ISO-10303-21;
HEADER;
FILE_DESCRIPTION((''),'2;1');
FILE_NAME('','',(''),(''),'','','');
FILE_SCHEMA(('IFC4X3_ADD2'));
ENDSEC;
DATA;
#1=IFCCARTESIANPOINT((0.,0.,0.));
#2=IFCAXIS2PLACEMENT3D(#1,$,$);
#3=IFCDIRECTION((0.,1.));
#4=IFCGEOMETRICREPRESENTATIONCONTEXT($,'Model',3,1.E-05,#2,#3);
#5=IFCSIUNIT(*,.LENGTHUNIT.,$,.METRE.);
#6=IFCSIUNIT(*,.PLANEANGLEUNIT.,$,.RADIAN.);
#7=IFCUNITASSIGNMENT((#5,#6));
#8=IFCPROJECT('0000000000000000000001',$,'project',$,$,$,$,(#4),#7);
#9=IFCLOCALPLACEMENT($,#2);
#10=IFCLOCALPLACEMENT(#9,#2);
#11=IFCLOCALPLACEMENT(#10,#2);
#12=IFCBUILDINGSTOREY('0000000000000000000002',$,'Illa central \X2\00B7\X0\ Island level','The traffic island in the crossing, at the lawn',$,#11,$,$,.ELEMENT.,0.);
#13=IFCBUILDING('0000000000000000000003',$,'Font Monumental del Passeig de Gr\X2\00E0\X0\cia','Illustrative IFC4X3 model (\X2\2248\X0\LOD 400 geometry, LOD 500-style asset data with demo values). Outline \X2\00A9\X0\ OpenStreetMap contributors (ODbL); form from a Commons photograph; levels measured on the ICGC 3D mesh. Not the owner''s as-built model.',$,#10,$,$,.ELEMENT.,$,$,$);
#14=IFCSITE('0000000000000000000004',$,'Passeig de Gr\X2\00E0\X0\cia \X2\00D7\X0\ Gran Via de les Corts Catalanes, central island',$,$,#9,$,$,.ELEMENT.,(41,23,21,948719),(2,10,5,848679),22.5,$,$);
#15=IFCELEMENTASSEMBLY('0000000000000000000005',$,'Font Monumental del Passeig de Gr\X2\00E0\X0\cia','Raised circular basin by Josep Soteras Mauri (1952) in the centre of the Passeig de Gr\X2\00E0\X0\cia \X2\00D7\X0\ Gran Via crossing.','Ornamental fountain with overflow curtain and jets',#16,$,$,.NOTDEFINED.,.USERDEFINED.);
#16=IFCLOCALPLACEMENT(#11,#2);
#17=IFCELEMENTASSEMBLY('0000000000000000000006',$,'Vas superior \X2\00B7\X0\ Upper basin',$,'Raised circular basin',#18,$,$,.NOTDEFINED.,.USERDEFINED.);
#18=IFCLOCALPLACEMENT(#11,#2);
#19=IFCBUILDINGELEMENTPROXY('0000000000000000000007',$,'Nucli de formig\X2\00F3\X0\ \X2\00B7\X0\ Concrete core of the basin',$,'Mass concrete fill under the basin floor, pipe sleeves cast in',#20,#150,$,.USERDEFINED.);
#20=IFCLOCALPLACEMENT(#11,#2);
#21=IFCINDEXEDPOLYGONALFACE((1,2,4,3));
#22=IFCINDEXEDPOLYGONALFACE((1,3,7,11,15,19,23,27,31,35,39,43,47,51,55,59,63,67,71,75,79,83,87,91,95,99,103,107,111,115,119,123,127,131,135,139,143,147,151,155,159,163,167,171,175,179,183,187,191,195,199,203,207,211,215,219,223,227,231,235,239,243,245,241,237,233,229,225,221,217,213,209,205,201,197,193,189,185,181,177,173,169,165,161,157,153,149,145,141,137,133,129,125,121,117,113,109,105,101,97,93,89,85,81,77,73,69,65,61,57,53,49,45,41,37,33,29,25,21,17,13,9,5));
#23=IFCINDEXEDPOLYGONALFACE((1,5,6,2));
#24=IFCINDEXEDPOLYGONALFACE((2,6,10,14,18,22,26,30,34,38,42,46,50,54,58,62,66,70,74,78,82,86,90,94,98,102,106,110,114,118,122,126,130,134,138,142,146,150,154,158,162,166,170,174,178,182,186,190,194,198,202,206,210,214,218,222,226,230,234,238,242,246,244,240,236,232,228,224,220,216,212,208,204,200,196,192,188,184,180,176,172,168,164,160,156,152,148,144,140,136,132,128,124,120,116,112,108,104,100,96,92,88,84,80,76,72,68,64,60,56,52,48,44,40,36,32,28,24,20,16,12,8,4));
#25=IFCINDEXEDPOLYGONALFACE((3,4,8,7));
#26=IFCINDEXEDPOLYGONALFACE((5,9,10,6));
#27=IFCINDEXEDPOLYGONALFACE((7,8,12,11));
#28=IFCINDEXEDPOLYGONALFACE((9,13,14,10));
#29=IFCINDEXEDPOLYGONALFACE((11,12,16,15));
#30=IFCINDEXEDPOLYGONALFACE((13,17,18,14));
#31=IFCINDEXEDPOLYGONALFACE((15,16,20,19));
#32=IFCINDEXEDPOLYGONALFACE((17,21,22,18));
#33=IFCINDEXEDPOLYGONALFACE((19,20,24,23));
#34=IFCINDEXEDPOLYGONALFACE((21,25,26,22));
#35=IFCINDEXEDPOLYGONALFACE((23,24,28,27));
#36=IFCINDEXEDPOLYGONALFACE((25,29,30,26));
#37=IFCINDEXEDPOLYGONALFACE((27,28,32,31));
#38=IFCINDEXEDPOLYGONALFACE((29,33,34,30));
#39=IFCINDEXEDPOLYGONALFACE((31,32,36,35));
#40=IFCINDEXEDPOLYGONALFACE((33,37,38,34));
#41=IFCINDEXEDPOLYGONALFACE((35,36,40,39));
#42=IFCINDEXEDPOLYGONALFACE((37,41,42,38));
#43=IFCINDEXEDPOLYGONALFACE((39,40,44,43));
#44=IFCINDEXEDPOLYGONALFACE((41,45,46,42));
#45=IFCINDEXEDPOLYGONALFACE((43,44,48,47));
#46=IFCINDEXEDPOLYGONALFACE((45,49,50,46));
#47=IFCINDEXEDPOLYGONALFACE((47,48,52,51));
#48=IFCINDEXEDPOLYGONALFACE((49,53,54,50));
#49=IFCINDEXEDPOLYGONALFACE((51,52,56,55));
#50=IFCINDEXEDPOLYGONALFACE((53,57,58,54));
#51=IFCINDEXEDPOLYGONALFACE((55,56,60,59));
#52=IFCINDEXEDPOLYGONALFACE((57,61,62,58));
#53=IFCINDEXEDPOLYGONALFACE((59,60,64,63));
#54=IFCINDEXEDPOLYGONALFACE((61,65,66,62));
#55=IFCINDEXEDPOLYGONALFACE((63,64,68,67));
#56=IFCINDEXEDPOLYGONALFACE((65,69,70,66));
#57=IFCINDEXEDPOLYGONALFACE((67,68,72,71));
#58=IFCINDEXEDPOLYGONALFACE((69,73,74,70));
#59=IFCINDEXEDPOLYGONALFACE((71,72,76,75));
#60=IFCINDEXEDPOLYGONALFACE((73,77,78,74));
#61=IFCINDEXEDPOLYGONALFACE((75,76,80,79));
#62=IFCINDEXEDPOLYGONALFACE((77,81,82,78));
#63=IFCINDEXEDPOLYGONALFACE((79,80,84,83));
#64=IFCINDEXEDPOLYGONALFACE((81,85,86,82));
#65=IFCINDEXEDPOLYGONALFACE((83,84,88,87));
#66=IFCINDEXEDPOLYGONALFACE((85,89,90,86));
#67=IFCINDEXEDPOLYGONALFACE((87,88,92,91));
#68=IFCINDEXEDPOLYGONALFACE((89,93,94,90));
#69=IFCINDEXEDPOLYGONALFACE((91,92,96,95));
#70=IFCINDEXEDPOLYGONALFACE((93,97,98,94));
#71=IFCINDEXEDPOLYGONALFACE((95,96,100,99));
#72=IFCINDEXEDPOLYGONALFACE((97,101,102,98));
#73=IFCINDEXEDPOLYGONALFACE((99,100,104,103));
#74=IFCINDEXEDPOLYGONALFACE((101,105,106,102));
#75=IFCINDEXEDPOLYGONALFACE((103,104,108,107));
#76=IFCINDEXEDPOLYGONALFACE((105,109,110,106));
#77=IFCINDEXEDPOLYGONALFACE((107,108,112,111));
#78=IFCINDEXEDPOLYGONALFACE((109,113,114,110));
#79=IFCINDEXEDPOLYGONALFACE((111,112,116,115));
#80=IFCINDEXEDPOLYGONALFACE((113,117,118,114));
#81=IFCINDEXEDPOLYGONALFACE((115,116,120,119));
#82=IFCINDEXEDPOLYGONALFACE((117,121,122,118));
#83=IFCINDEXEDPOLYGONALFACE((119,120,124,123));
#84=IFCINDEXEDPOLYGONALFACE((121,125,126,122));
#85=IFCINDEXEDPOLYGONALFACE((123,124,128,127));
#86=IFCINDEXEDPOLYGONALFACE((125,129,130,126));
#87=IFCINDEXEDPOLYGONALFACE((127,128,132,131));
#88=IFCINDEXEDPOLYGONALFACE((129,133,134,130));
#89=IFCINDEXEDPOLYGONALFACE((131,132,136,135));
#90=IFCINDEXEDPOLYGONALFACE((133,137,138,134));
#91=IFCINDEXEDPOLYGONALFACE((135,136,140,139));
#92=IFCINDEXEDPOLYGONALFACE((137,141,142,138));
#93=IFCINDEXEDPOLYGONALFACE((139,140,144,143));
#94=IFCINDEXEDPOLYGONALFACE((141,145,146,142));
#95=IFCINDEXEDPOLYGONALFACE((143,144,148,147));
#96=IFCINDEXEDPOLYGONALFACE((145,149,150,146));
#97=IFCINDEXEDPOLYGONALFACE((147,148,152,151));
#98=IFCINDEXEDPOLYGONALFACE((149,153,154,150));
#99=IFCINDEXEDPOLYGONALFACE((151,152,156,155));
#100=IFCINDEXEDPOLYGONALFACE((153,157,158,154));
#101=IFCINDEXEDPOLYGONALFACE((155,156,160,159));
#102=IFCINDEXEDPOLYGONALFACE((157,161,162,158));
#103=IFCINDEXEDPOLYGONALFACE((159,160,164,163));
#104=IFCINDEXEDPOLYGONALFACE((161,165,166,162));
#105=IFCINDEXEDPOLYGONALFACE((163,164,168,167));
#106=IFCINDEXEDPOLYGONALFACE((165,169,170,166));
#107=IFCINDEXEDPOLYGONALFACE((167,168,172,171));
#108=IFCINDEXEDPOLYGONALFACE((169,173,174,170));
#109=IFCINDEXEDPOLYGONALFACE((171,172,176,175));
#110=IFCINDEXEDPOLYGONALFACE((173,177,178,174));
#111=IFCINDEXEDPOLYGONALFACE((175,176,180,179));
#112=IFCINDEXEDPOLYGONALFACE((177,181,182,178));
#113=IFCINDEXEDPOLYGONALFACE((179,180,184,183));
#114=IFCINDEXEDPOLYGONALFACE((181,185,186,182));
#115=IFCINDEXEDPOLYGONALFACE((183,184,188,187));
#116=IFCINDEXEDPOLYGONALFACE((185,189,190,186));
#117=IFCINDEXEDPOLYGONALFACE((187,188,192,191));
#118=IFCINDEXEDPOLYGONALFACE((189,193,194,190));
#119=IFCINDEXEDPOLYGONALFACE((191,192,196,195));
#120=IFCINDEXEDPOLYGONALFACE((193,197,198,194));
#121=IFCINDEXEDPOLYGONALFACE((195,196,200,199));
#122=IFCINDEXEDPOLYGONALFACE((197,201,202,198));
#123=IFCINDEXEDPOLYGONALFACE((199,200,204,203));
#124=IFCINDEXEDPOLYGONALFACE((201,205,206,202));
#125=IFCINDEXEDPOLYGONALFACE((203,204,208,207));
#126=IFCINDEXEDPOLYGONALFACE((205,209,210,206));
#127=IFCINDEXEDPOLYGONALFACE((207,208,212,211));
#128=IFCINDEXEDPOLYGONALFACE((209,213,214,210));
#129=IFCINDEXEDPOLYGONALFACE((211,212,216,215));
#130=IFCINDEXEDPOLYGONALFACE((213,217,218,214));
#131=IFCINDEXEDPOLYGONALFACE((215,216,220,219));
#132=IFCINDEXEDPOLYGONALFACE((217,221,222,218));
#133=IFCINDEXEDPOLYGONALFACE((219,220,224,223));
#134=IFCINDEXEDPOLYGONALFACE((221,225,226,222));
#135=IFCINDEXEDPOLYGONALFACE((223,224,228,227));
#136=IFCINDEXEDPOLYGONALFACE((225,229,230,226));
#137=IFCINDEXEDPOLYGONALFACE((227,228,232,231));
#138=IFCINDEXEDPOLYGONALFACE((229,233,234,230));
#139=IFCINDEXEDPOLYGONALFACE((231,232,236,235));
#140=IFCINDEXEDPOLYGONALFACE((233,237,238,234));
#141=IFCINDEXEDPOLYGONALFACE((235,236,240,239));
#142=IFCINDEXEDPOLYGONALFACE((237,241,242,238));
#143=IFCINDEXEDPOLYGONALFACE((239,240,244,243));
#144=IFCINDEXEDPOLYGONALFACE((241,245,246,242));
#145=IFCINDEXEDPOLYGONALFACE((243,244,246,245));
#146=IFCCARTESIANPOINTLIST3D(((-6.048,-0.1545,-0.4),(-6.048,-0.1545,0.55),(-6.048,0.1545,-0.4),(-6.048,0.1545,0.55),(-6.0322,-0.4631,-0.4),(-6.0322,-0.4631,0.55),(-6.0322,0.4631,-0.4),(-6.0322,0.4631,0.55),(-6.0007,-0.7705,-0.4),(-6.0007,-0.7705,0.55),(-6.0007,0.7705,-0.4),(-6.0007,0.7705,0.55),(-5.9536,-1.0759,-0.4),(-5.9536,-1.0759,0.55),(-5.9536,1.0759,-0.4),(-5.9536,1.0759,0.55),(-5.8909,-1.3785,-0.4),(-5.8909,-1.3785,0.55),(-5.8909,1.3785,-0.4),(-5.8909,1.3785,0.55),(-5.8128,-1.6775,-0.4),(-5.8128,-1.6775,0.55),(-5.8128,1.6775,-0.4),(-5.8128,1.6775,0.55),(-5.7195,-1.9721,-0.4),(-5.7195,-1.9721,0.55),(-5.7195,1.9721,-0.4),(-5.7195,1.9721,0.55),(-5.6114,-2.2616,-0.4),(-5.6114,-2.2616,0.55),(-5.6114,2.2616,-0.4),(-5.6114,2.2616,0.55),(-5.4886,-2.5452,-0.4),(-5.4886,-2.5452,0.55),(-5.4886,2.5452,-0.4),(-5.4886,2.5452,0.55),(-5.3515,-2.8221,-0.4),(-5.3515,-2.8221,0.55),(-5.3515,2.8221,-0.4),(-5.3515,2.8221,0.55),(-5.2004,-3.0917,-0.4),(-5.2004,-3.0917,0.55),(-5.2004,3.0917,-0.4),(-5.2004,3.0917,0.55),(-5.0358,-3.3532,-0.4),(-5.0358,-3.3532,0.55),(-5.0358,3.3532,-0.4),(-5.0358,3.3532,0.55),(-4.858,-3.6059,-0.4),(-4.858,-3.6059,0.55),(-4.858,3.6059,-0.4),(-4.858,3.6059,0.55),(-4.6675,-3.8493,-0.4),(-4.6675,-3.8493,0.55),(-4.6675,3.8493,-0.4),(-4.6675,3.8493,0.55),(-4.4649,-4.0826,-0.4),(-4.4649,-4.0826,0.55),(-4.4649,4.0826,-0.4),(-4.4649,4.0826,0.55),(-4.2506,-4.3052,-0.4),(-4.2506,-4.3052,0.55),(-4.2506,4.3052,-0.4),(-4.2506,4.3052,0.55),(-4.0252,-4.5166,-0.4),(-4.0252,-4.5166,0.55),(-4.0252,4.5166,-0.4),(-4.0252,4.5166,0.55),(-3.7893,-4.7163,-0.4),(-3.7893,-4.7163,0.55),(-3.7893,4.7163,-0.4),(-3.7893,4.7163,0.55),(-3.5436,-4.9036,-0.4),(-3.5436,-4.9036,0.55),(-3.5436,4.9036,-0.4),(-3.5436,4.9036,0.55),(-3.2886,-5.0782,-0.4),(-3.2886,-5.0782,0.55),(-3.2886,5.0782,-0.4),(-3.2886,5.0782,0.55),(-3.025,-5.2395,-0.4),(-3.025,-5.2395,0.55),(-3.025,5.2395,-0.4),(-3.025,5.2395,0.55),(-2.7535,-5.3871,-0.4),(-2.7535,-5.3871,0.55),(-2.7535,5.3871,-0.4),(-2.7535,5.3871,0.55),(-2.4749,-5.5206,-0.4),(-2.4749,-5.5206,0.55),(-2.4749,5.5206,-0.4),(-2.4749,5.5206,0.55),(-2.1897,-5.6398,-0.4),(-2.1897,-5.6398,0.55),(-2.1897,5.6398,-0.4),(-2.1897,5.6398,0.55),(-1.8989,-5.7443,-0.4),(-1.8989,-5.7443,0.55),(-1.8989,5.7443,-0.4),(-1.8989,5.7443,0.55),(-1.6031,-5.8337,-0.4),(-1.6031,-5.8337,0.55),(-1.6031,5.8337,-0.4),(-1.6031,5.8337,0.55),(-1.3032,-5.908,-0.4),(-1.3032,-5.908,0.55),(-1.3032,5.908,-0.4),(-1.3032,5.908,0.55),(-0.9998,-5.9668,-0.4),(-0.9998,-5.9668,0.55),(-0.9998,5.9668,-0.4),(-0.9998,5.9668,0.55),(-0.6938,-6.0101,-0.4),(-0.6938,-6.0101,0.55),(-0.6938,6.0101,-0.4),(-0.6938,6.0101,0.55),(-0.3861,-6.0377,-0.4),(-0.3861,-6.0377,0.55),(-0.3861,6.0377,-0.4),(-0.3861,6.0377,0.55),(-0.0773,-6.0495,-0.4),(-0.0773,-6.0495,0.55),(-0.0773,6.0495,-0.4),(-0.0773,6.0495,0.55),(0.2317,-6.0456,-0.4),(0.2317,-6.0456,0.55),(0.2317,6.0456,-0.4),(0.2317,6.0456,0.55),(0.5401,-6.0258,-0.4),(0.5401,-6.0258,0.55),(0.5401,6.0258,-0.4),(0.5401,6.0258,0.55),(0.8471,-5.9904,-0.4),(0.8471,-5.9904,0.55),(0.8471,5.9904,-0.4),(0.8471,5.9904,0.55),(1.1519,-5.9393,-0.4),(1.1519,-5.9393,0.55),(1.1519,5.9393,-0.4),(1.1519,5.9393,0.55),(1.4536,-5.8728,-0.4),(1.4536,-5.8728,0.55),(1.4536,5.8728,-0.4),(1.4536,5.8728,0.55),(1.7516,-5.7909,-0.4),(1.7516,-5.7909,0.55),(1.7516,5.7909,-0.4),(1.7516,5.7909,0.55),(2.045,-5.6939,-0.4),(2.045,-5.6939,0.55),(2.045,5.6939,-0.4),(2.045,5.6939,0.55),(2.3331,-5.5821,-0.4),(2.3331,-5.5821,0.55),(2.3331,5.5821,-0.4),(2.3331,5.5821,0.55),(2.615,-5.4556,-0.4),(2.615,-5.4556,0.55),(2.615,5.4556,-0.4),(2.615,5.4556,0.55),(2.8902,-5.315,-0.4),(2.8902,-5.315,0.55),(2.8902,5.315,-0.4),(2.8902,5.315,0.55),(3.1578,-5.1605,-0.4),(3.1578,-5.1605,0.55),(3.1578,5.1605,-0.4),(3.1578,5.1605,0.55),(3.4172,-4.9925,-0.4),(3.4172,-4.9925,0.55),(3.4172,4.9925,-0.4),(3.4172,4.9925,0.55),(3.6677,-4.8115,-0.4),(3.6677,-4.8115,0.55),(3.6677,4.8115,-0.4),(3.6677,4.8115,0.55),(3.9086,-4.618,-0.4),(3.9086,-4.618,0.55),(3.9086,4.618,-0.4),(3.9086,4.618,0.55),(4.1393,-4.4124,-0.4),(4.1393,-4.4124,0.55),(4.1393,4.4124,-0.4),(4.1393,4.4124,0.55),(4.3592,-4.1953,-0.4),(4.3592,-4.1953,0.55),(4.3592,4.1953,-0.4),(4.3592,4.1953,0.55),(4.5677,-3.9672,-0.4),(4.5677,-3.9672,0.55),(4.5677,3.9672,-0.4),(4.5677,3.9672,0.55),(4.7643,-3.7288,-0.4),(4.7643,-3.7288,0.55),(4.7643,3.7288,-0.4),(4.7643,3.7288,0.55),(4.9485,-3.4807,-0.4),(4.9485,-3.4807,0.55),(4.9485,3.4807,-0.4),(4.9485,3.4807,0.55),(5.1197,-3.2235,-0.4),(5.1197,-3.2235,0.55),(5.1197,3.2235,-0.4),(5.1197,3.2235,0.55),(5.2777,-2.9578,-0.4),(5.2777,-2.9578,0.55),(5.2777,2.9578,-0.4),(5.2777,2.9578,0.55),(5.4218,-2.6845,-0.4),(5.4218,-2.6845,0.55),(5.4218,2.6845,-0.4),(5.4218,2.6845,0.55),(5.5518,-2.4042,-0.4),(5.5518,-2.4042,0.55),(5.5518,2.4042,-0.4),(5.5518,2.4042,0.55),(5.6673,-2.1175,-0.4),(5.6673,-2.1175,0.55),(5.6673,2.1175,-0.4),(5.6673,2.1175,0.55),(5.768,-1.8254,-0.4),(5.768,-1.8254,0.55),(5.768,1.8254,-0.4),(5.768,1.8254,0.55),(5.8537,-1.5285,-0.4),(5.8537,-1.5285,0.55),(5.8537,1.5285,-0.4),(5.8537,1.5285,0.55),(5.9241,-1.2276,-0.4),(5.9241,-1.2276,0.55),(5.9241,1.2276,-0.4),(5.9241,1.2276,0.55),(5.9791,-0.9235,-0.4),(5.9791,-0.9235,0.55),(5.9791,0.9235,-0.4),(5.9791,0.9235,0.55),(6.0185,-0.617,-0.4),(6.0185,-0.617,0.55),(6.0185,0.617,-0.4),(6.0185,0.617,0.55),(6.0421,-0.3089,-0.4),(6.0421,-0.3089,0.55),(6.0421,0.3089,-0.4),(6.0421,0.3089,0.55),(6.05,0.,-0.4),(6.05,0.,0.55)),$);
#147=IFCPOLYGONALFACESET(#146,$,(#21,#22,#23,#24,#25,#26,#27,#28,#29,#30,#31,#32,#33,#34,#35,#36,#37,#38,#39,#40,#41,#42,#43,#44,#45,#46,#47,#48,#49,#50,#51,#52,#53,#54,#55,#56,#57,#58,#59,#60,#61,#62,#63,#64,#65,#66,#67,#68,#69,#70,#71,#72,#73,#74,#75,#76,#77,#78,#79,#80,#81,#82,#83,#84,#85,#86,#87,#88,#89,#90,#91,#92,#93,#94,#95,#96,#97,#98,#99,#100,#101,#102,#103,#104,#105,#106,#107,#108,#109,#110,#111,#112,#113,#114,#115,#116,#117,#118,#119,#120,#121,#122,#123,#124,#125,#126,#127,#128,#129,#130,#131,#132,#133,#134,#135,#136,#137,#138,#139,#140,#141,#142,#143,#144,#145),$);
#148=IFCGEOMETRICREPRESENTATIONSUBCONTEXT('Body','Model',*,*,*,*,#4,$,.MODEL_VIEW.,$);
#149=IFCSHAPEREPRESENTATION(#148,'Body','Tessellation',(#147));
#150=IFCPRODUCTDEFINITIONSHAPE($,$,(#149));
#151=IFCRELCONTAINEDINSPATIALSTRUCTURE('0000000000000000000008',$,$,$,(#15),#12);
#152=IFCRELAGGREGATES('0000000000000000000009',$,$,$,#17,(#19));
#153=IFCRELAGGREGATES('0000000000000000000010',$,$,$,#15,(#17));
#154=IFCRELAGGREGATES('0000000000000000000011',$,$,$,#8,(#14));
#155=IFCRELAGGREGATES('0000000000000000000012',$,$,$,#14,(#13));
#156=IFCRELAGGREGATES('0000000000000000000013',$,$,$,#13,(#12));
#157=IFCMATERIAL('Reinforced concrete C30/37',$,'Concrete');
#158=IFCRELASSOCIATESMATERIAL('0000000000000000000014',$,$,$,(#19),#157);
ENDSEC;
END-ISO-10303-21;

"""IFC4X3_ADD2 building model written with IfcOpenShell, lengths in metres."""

from ifc_helpers import new_model, si_unit, direction, frame, origin, origin_2d_with_axis, place, context, subcontext, project, spatial, circle, extrude, material, element, aggregate, save


model = new_model("IFC4X3_ADD2")

# Units and contexts
model_context = context("Model", 3, precision=1e-05, world=origin(), true_north=direction((0.0, 1.0)))
body_context = subcontext(model_context, "Body", "Model", "MODEL_VIEW")
ifc_project = project(units=[si_unit("LENGTHUNIT", "METRE"), si_unit("PLANEANGLEUNIT", "RADIAN")], contexts=[model_context])

# Site, building, storey
site_placement = place(None, origin())
site = spatial("IfcSite", under=ifc_project, at=site_placement, Name="Passeig de Gràcia × Gran Via de les Corts Catalanes, central island", CompositionType="ELEMENT", RefLatitude=(41, 23, 21, 948719), RefLongitude=(2, 10, 5, 848679), RefElevation=22.5)
building_placement = place(site_placement, origin())
building = spatial("IfcBuilding", under=site, at=building_placement, Name="Font Monumental del Passeig de Gràcia", Description="Illustrative IFC4X3 model (≈LOD 400 geometry, LOD 500-style asset data with demo values). Outline © OpenStreetMap contributors (ODbL); form from a Commons photograph; levels measured on the ICGC 3D mesh. Not the owner's as-built model.", CompositionType="ELEMENT")
storey_placement = place(building_placement, origin())
storey = spatial("IfcBuildingStorey", under=building, at=storey_placement, Name="Illa central · Island level", Description="The traffic island in the crossing, at the lawn", CompositionType="ELEMENT", Elevation=0.0)

# Element assemblies, building element proxy
assembly_1_placement = place(building_placement, origin())
assembly_1 = element("IfcElementAssembly", 1, at=assembly_1_placement, inside=storey, Name="Font Monumental del Passeig de Gràcia", Description="Raised circular basin by Josep Soteras Mauri (1952) in the centre of the Passeig de Gràcia × Gran Via crossing.", ObjectType="Ornamental fountain with overflow curtain and jets", AssemblyPlace="NOTDEFINED", PredefinedType="USERDEFINED")
assembly_2_placement = place(building_placement, origin())
assembly_2 = element("IfcElementAssembly", 2, at=assembly_2_placement, Name="Vas superior · Upper basin", ObjectType="Raised circular basin", AssemblyPlace="NOTDEFINED", PredefinedType="USERDEFINED")
ifc_material_1 = material(Name="Reinforced concrete C30/37", Category="Concrete")
proxy_1_placement = place(building_placement, origin())
proxy_1 = element("IfcBuildingElementProxy", 3, at=proxy_1_placement, material=ifc_material_1, Name="Nucli de formigó · Concrete core of the basin", ObjectType="Mass concrete fill under the basin floor, pipe sleeves cast in", PredefinedType="USERDEFINED", context=body_context, shape_type="SweptSolid", body=[
    extrude(circle(Radius=6.05, at=origin_2d_with_axis()), frame((0.0, 0.0, -0.4)), (0.0, 0.0, 1.0), 0.95),
])
aggregate(assembly_2, [proxy_1])
aggregate(assembly_1, [assembly_2])

save(model, "model.ifc")
